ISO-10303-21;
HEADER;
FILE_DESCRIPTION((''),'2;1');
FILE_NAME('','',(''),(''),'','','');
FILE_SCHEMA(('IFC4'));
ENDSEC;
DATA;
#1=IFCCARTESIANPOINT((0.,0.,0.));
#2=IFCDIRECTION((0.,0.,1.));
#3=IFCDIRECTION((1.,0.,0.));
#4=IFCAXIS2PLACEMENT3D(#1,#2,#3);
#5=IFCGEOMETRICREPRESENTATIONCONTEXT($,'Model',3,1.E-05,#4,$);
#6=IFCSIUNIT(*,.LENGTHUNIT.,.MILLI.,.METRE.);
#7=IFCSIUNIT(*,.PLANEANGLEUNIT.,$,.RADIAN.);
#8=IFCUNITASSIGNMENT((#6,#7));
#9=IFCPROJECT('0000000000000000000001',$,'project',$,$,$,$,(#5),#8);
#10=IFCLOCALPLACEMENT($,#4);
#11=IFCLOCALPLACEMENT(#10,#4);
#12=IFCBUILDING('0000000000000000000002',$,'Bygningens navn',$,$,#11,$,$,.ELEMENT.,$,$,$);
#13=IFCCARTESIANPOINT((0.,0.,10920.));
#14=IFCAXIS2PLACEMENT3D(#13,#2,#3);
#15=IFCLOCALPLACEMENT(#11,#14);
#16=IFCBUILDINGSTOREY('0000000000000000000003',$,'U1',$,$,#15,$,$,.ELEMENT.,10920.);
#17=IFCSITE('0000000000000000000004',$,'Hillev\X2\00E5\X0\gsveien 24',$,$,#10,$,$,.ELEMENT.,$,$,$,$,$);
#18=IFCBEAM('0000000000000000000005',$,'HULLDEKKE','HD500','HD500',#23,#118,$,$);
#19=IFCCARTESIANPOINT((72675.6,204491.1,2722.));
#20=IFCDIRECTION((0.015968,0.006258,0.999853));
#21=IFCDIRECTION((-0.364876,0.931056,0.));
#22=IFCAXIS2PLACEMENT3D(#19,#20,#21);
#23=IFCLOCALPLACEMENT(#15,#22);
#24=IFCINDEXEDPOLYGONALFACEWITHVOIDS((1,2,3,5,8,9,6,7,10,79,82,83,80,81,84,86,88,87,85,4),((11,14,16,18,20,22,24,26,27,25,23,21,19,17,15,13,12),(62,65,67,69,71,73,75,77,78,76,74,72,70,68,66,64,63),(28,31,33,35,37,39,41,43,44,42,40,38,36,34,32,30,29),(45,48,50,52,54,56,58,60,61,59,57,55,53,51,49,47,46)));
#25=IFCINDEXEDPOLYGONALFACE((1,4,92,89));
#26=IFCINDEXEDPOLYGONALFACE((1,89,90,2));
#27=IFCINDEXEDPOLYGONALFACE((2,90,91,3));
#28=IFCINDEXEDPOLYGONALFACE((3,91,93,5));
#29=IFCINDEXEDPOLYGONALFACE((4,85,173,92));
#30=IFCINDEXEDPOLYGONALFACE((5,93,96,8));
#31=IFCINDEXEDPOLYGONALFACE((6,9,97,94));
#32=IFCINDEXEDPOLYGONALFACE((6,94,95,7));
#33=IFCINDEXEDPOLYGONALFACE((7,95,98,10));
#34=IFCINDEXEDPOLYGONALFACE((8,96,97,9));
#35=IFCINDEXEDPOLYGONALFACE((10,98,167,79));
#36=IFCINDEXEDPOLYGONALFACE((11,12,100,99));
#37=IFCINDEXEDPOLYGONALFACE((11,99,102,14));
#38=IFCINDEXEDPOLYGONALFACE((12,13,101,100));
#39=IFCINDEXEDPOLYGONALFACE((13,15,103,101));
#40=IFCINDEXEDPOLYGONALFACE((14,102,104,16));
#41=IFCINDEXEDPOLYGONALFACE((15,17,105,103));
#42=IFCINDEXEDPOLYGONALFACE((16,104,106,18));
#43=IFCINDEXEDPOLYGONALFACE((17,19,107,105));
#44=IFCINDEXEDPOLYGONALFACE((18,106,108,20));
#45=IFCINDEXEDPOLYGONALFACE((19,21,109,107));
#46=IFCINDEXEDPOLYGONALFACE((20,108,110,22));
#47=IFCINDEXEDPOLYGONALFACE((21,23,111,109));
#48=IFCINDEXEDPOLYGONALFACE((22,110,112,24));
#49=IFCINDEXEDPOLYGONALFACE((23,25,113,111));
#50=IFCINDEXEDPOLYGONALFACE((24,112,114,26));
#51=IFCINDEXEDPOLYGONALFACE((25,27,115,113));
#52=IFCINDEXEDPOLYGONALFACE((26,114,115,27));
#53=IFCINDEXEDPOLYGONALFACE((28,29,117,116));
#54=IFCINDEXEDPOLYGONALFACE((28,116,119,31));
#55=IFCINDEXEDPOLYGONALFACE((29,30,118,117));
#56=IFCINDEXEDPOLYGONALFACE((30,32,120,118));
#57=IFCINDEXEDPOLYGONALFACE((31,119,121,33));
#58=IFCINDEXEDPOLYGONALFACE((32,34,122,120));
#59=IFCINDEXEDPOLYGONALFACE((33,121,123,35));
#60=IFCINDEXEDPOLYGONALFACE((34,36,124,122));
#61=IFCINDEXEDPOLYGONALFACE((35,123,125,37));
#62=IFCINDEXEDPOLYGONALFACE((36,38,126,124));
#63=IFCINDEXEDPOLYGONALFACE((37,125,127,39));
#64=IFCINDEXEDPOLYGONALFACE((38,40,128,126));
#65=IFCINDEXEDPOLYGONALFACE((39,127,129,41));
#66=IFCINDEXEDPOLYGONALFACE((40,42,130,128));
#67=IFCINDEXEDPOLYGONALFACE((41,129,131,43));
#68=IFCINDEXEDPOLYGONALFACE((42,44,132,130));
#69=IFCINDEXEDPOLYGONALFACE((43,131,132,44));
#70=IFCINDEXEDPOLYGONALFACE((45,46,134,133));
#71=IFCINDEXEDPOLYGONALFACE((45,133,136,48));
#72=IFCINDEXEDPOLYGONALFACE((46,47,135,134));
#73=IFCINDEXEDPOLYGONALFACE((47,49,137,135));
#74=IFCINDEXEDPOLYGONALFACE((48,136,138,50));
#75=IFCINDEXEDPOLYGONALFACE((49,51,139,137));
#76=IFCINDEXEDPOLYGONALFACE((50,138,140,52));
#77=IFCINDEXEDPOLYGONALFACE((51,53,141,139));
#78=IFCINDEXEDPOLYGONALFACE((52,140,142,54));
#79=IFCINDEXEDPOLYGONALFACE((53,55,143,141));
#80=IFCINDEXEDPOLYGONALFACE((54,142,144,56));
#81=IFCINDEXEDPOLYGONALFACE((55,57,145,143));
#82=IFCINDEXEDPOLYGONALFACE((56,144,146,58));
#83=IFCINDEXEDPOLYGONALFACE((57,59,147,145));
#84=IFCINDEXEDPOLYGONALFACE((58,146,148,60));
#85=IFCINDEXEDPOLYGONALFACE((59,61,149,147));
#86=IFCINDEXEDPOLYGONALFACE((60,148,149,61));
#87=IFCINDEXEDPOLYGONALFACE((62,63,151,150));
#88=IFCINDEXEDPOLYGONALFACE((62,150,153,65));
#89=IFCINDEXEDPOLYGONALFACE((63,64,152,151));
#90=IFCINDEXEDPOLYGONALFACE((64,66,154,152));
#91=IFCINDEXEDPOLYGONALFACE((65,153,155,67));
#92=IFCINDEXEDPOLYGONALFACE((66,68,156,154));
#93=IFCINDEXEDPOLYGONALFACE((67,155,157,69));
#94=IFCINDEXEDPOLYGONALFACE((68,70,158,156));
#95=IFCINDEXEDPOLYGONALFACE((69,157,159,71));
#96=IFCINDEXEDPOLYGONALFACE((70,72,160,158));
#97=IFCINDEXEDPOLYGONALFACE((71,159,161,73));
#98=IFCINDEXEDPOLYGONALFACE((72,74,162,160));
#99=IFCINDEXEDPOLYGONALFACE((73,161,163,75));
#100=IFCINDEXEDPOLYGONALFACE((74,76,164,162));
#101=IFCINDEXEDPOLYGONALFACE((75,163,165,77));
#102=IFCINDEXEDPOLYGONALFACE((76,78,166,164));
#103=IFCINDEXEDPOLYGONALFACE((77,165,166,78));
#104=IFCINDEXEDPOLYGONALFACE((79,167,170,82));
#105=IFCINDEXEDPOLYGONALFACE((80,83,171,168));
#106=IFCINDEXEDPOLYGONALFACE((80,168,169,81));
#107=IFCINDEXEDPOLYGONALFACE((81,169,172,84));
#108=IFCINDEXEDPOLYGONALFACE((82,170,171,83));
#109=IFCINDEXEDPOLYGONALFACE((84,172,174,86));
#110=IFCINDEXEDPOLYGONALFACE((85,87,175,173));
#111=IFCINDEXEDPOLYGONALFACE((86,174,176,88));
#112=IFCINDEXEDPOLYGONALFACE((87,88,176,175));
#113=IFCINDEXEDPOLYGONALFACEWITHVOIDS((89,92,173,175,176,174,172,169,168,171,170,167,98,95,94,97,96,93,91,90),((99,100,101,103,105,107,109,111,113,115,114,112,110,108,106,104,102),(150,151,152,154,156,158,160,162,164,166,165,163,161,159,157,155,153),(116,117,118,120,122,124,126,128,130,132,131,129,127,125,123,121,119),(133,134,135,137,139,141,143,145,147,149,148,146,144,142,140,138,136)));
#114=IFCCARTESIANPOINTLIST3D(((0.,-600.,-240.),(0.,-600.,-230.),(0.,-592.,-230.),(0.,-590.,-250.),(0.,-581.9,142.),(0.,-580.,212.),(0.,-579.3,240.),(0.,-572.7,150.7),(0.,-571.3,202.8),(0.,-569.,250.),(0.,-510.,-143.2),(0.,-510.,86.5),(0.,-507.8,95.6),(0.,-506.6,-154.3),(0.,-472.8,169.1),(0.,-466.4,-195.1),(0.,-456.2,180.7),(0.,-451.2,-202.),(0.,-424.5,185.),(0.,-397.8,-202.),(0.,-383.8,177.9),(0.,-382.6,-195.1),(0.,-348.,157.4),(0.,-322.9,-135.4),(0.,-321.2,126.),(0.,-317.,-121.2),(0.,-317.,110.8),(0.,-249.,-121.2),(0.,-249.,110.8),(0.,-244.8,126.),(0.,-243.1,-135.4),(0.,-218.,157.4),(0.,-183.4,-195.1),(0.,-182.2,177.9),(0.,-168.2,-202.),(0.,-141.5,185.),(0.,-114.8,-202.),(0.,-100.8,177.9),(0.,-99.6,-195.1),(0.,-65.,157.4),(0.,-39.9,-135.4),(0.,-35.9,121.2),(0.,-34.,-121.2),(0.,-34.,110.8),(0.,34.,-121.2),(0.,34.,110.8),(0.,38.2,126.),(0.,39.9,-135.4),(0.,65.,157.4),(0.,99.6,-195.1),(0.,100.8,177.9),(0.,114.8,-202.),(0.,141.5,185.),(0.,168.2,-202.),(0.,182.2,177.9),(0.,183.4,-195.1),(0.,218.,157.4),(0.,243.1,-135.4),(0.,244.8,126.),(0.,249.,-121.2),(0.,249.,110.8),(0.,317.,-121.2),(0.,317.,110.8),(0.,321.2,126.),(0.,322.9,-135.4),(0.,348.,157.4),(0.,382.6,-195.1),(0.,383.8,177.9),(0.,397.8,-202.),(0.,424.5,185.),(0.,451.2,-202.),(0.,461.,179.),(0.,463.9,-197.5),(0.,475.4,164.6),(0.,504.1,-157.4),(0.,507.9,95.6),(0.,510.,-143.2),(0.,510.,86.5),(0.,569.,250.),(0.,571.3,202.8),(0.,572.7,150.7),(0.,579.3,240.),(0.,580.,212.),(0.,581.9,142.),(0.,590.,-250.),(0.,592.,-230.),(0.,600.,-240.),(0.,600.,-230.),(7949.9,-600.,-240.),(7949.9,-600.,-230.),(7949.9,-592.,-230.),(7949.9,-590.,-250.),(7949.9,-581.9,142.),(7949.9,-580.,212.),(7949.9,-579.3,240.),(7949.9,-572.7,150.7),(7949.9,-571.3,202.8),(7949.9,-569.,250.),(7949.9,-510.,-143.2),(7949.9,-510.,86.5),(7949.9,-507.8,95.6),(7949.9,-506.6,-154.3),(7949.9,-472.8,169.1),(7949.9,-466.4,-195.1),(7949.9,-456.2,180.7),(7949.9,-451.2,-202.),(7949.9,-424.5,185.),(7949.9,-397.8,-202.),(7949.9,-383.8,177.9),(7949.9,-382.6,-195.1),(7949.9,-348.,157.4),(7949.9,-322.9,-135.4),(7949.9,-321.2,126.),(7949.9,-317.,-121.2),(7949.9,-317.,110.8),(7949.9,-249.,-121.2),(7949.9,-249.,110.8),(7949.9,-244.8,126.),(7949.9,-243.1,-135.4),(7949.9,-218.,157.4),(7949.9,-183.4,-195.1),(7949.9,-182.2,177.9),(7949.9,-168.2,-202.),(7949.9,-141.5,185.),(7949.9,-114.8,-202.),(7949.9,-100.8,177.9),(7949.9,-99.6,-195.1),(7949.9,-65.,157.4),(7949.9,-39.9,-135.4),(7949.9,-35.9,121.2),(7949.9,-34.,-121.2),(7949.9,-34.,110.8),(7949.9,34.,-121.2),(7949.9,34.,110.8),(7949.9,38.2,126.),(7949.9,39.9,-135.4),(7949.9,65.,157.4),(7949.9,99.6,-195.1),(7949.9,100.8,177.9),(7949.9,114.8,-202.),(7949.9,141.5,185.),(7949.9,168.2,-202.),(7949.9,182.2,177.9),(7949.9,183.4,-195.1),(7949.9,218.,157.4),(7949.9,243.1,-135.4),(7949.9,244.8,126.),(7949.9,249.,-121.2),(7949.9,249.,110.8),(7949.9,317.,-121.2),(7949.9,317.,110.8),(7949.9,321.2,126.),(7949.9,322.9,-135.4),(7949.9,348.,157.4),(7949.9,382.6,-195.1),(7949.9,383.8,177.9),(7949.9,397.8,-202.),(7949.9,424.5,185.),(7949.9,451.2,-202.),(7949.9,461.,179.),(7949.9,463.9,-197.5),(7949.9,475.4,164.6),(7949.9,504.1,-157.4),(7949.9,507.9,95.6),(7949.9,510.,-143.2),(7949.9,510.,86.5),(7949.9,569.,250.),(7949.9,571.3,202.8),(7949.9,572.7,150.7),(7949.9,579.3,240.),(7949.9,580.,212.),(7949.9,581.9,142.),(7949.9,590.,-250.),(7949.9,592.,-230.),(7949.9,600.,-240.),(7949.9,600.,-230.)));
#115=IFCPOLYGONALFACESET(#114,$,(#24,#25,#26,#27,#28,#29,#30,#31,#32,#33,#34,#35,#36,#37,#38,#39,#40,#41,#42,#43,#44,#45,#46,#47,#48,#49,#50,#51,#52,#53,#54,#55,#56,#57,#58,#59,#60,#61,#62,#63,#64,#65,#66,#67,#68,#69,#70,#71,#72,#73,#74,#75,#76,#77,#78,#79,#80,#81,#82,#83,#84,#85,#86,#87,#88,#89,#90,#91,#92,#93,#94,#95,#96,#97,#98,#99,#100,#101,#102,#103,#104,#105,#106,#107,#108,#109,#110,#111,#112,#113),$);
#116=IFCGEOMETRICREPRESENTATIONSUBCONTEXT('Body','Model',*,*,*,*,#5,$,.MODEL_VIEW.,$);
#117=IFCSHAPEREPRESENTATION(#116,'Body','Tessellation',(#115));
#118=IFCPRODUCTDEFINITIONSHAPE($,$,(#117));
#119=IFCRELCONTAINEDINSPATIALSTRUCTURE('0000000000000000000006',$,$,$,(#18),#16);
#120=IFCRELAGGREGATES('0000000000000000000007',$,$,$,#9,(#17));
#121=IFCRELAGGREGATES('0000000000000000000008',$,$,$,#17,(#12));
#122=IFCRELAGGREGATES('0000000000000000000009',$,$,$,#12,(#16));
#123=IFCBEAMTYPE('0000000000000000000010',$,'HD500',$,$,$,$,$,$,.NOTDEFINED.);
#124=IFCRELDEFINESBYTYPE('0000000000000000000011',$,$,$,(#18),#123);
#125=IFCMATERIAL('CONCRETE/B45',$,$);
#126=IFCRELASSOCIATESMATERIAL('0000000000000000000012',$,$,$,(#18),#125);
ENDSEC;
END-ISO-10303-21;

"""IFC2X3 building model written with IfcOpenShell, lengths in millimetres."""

from ifc_helpers import new_model, si_unit, frame, origin_with_axes, place, context, subcontext, project, spatial, polyline, outline, extrude, material, type_object, element, save


model = new_model("IFC2X3")

# Units and contexts
model_context = context("Model", 3, precision=1e-05, world=origin_with_axes())
body_context = subcontext(model_context, "Body", "Model", "MODEL_VIEW")
ifc_project = project(units=[si_unit("LENGTHUNIT", "METRE", prefix="MILLI"), si_unit("PLANEANGLEUNIT", "RADIAN")], contexts=[model_context])

# Site, building, storey
site_placement = place(None, origin_with_axes())
site = spatial("IfcSite", under=ifc_project, at=site_placement, Name="Hillevågsveien 24", CompositionType="ELEMENT")
building_placement = place(site_placement, origin_with_axes())
building = spatial("IfcBuilding", under=site, at=building_placement, Name="Bygningens navn", CompositionType="ELEMENT")
storey_placement = place(building_placement, frame((0.0, 0.0, 10920.0), z_axis=(0.0, 0.0, 1.0), x_axis=(1.0, 0.0, 0.0)))
storey = spatial("IfcBuildingStorey", under=building, at=storey_placement, Name="U1", CompositionType="ELEMENT", Elevation=10920.0)

# Beam
ifc_material_1 = material(Name="CONCRETE/B45")
beam_type_1 = type_object("IfcBeamType", Name="HD500", PredefinedType="NOTDEFINED")
beam_1_placement = place(storey_placement, frame((72675.6, 204491.1, 2722.0), z_axis=(0.015968, 0.006258, 0.999853), x_axis=(-0.364876, 0.931056, 0.0)))
element("IfcBeam", 1, at=beam_1_placement, inside=storey, type_object=beam_type_1, material=ifc_material_1, Name="HULLDEKKE", Description="HD500", ObjectType="HD500", context=body_context, shape_type="SweptSolid", body=[
    extrude(outline(polyline([(581.9, 142.0), (592.0, -230.0), (600.0, -230.0), (600.0, -240.0), (590.0, -250.0), (-590.0, -250.0), (-600.0, -240.0), (-600.0, -230.0), (-592.0, -230.0), (-581.9, 142.0), (-572.7, 150.7), (-571.3, 202.8), (-580.0, 212.0), (-579.3, 240.0), (-569.0, 250.0), (569.0, 250.0), (579.3, 240.0), (580.0, 212.0), (571.3, 202.8), (572.7, 150.7), (581.9, 142.0)]), holes=[polyline([(466.4, -195.1), (506.6, -154.3), (510.0, -143.2), (510.0, 86.5), (507.8, 95.6), (472.8, 169.1), (456.2, 180.7), (424.5, 185.0), (383.8, 177.9), (348.0, 157.4), (321.2, 126.0), (317.0, 110.8), (317.0, -121.2), (322.9, -135.4), (382.6, -195.1), (397.8, -202.0), (451.2, -202.0), (466.4, -195.1)]), polyline([(183.4, -195.1), (243.1, -135.4), (249.0, -121.2), (249.0, 110.8), (244.8, 126.0), (218.0, 157.4), (182.2, 177.9), (141.5, 185.0), (100.8, 177.9), (65.0, 157.4), (35.9, 121.2), (34.0, 110.8), (34.0, -121.2), (39.9, -135.4), (99.6, -195.1), (114.8, -202.0), (168.2, -202.0), (183.4, -195.1)]), polyline([(-99.6, -195.1), (-39.9, -135.4), (-34.0, -121.2), (-34.0, 110.8), (-38.2, 126.0), (-65.0, 157.4), (-100.8, 177.9), (-141.5, 185.0), (-182.2, 177.9), (-218.0, 157.4), (-244.8, 126.0), (-249.0, 110.8), (-249.0, -121.2), (-243.1, -135.4), (-183.4, -195.1), (-168.2, -202.0), (-114.8, -202.0), (-99.6, -195.1)]), polyline([(-382.6, -195.1), (-322.9, -135.4), (-317.0, -121.2), (-317.0, 110.8), (-321.2, 126.0), (-348.0, 157.4), (-383.8, 177.9), (-424.5, 185.0), (-461.0, 179.0), (-475.4, 164.6), (-507.9, 95.6), (-510.0, 86.5), (-510.0, -143.2), (-504.1, -157.4), (-463.9, -197.5), (-451.2, -202.0), (-397.8, -202.0), (-382.6, -195.1)])]), frame((7949.9, 0.0, 0.0), z_axis=(-1.0, 0.0, 0.0), x_axis=(0.0, -1.0, 0.0)), (0.0, 0.0, 1.0), 7949.9),
])

save(model, "model.ifc")
